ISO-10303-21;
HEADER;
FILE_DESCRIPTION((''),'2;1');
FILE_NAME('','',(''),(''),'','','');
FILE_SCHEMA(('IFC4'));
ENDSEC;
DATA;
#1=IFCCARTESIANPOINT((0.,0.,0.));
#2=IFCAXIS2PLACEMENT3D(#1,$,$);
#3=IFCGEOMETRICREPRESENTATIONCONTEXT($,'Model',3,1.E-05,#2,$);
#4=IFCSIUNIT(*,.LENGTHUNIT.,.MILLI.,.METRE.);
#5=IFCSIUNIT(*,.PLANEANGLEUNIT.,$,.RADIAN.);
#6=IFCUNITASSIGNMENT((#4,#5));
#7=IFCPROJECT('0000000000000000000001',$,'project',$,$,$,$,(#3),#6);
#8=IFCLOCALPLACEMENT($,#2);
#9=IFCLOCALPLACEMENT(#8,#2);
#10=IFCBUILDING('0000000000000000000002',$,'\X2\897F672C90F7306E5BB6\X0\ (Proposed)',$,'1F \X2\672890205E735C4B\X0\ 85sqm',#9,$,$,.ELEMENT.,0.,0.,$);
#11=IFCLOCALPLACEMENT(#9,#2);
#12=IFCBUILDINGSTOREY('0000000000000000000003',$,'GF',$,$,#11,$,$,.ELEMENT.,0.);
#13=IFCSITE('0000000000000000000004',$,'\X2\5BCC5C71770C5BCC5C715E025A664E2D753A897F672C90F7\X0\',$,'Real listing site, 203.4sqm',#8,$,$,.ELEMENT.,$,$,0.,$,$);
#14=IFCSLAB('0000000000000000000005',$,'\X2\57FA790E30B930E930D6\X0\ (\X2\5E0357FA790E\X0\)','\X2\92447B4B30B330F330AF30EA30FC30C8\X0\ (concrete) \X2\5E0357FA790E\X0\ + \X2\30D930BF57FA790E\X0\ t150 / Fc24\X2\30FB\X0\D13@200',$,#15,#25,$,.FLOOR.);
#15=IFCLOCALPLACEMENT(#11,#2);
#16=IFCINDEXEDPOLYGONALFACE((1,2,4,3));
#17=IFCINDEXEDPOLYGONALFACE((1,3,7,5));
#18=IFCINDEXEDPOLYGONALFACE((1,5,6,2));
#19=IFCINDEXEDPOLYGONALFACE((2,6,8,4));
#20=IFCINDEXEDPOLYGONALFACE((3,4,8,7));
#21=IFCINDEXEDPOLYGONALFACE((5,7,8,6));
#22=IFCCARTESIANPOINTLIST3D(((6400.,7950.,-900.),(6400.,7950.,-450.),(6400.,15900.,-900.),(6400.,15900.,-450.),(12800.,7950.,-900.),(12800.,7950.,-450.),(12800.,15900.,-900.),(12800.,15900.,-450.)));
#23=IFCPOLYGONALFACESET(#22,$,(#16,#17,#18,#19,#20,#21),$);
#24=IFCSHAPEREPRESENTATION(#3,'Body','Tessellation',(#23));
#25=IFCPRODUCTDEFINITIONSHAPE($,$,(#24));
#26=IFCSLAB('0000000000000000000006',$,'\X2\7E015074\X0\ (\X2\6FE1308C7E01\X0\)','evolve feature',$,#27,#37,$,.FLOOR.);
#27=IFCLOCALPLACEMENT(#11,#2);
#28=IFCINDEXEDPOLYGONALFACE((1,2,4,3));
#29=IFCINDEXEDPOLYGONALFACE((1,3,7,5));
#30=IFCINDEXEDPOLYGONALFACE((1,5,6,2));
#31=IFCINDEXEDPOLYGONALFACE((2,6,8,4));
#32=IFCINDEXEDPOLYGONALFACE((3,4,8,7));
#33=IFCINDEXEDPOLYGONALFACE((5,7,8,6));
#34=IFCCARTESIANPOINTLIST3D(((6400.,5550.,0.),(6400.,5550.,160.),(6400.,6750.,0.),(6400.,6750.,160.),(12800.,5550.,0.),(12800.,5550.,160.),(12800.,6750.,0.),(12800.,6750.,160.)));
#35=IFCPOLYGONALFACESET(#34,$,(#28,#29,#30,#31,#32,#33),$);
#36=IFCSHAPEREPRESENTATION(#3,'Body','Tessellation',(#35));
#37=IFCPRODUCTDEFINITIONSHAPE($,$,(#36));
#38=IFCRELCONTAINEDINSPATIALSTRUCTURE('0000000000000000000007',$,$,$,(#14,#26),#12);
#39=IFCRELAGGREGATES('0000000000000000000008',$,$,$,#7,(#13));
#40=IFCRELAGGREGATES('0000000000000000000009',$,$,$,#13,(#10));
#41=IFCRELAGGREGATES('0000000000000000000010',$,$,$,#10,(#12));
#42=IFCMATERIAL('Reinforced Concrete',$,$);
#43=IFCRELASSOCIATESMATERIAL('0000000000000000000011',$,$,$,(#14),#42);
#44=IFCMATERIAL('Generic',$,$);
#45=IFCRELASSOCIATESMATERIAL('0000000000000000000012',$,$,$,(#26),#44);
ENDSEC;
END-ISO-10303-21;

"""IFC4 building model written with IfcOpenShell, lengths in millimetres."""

from ifc_helpers import new_model, si_unit, frame, frame_2d, origin, place, context, project, spatial, rectangle, extrude, material, element, save


model = new_model("IFC4")

# Units and contexts
model_context = context("Model", 3, precision=1e-05, world=origin())
ifc_project = project(units=[si_unit("LENGTHUNIT", "METRE", prefix="MILLI"), si_unit("PLANEANGLEUNIT", "RADIAN")], contexts=[model_context])

# Site, building, storey
site_placement = place(None, origin())
site = spatial("IfcSite", under=ifc_project, at=site_placement, Name="富山県富山市婦中町西本郷", ObjectType="Real listing site, 203.4sqm", CompositionType="ELEMENT", RefElevation=0.0)
building_placement = place(site_placement, origin())
building = spatial("IfcBuilding", under=site, at=building_placement, Name="西本郷の家 (Proposed)", ObjectType="1F 木造平屋 85sqm", CompositionType="ELEMENT", ElevationOfRefHeight=0.0, ElevationOfTerrain=0.0)
storey_placement = place(building_placement, origin())
storey = spatial("IfcBuildingStorey", under=building, at=storey_placement, Name="GF", CompositionType="ELEMENT", Elevation=0.0)

# Slabs
ifc_material_1 = material(Name="Reinforced Concrete")
slab_1_placement = place(storey_placement, frame((3200.0, 3975.0, -450.0)))
element("IfcSlab", 1, at=slab_1_placement, inside=storey, material=ifc_material_1, Name="基礎スラブ (布基礎)", Description="鉄筋コンクリート (concrete) 布基礎 + ベタ基礎 t150 / Fc24・D13@200", PredefinedType="FLOOR", context=model_context, shape_type="SweptSolid", body=[
    extrude(rectangle(XDim=6400.0, YDim=7950.0, at=frame_2d((3200.0, 3975.0))), frame((3200.0, 3975.0, -450.0)), (0.0, 0.0, 1.0), 450.0),
])
ifc_material_2 = material(Name="Generic")
slab_2_placement = place(storey_placement, frame((3200.0, 2775.0, 0.0)))
element("IfcSlab", 2, at=slab_2_placement, inside=storey, material=ifc_material_2, Name="縁側 (濡れ縁)", Description="evolve feature", PredefinedType="FLOOR", context=model_context, shape_type="SweptSolid", body=[
    extrude(rectangle(XDim=6400.0, YDim=1200.0, at=frame_2d((3200.0, 600.0))), frame((3200.0, 2775.0, 0.0)), (0.0, 0.0, 1.0), 160.0),
])

save(model, "model.ifc")
